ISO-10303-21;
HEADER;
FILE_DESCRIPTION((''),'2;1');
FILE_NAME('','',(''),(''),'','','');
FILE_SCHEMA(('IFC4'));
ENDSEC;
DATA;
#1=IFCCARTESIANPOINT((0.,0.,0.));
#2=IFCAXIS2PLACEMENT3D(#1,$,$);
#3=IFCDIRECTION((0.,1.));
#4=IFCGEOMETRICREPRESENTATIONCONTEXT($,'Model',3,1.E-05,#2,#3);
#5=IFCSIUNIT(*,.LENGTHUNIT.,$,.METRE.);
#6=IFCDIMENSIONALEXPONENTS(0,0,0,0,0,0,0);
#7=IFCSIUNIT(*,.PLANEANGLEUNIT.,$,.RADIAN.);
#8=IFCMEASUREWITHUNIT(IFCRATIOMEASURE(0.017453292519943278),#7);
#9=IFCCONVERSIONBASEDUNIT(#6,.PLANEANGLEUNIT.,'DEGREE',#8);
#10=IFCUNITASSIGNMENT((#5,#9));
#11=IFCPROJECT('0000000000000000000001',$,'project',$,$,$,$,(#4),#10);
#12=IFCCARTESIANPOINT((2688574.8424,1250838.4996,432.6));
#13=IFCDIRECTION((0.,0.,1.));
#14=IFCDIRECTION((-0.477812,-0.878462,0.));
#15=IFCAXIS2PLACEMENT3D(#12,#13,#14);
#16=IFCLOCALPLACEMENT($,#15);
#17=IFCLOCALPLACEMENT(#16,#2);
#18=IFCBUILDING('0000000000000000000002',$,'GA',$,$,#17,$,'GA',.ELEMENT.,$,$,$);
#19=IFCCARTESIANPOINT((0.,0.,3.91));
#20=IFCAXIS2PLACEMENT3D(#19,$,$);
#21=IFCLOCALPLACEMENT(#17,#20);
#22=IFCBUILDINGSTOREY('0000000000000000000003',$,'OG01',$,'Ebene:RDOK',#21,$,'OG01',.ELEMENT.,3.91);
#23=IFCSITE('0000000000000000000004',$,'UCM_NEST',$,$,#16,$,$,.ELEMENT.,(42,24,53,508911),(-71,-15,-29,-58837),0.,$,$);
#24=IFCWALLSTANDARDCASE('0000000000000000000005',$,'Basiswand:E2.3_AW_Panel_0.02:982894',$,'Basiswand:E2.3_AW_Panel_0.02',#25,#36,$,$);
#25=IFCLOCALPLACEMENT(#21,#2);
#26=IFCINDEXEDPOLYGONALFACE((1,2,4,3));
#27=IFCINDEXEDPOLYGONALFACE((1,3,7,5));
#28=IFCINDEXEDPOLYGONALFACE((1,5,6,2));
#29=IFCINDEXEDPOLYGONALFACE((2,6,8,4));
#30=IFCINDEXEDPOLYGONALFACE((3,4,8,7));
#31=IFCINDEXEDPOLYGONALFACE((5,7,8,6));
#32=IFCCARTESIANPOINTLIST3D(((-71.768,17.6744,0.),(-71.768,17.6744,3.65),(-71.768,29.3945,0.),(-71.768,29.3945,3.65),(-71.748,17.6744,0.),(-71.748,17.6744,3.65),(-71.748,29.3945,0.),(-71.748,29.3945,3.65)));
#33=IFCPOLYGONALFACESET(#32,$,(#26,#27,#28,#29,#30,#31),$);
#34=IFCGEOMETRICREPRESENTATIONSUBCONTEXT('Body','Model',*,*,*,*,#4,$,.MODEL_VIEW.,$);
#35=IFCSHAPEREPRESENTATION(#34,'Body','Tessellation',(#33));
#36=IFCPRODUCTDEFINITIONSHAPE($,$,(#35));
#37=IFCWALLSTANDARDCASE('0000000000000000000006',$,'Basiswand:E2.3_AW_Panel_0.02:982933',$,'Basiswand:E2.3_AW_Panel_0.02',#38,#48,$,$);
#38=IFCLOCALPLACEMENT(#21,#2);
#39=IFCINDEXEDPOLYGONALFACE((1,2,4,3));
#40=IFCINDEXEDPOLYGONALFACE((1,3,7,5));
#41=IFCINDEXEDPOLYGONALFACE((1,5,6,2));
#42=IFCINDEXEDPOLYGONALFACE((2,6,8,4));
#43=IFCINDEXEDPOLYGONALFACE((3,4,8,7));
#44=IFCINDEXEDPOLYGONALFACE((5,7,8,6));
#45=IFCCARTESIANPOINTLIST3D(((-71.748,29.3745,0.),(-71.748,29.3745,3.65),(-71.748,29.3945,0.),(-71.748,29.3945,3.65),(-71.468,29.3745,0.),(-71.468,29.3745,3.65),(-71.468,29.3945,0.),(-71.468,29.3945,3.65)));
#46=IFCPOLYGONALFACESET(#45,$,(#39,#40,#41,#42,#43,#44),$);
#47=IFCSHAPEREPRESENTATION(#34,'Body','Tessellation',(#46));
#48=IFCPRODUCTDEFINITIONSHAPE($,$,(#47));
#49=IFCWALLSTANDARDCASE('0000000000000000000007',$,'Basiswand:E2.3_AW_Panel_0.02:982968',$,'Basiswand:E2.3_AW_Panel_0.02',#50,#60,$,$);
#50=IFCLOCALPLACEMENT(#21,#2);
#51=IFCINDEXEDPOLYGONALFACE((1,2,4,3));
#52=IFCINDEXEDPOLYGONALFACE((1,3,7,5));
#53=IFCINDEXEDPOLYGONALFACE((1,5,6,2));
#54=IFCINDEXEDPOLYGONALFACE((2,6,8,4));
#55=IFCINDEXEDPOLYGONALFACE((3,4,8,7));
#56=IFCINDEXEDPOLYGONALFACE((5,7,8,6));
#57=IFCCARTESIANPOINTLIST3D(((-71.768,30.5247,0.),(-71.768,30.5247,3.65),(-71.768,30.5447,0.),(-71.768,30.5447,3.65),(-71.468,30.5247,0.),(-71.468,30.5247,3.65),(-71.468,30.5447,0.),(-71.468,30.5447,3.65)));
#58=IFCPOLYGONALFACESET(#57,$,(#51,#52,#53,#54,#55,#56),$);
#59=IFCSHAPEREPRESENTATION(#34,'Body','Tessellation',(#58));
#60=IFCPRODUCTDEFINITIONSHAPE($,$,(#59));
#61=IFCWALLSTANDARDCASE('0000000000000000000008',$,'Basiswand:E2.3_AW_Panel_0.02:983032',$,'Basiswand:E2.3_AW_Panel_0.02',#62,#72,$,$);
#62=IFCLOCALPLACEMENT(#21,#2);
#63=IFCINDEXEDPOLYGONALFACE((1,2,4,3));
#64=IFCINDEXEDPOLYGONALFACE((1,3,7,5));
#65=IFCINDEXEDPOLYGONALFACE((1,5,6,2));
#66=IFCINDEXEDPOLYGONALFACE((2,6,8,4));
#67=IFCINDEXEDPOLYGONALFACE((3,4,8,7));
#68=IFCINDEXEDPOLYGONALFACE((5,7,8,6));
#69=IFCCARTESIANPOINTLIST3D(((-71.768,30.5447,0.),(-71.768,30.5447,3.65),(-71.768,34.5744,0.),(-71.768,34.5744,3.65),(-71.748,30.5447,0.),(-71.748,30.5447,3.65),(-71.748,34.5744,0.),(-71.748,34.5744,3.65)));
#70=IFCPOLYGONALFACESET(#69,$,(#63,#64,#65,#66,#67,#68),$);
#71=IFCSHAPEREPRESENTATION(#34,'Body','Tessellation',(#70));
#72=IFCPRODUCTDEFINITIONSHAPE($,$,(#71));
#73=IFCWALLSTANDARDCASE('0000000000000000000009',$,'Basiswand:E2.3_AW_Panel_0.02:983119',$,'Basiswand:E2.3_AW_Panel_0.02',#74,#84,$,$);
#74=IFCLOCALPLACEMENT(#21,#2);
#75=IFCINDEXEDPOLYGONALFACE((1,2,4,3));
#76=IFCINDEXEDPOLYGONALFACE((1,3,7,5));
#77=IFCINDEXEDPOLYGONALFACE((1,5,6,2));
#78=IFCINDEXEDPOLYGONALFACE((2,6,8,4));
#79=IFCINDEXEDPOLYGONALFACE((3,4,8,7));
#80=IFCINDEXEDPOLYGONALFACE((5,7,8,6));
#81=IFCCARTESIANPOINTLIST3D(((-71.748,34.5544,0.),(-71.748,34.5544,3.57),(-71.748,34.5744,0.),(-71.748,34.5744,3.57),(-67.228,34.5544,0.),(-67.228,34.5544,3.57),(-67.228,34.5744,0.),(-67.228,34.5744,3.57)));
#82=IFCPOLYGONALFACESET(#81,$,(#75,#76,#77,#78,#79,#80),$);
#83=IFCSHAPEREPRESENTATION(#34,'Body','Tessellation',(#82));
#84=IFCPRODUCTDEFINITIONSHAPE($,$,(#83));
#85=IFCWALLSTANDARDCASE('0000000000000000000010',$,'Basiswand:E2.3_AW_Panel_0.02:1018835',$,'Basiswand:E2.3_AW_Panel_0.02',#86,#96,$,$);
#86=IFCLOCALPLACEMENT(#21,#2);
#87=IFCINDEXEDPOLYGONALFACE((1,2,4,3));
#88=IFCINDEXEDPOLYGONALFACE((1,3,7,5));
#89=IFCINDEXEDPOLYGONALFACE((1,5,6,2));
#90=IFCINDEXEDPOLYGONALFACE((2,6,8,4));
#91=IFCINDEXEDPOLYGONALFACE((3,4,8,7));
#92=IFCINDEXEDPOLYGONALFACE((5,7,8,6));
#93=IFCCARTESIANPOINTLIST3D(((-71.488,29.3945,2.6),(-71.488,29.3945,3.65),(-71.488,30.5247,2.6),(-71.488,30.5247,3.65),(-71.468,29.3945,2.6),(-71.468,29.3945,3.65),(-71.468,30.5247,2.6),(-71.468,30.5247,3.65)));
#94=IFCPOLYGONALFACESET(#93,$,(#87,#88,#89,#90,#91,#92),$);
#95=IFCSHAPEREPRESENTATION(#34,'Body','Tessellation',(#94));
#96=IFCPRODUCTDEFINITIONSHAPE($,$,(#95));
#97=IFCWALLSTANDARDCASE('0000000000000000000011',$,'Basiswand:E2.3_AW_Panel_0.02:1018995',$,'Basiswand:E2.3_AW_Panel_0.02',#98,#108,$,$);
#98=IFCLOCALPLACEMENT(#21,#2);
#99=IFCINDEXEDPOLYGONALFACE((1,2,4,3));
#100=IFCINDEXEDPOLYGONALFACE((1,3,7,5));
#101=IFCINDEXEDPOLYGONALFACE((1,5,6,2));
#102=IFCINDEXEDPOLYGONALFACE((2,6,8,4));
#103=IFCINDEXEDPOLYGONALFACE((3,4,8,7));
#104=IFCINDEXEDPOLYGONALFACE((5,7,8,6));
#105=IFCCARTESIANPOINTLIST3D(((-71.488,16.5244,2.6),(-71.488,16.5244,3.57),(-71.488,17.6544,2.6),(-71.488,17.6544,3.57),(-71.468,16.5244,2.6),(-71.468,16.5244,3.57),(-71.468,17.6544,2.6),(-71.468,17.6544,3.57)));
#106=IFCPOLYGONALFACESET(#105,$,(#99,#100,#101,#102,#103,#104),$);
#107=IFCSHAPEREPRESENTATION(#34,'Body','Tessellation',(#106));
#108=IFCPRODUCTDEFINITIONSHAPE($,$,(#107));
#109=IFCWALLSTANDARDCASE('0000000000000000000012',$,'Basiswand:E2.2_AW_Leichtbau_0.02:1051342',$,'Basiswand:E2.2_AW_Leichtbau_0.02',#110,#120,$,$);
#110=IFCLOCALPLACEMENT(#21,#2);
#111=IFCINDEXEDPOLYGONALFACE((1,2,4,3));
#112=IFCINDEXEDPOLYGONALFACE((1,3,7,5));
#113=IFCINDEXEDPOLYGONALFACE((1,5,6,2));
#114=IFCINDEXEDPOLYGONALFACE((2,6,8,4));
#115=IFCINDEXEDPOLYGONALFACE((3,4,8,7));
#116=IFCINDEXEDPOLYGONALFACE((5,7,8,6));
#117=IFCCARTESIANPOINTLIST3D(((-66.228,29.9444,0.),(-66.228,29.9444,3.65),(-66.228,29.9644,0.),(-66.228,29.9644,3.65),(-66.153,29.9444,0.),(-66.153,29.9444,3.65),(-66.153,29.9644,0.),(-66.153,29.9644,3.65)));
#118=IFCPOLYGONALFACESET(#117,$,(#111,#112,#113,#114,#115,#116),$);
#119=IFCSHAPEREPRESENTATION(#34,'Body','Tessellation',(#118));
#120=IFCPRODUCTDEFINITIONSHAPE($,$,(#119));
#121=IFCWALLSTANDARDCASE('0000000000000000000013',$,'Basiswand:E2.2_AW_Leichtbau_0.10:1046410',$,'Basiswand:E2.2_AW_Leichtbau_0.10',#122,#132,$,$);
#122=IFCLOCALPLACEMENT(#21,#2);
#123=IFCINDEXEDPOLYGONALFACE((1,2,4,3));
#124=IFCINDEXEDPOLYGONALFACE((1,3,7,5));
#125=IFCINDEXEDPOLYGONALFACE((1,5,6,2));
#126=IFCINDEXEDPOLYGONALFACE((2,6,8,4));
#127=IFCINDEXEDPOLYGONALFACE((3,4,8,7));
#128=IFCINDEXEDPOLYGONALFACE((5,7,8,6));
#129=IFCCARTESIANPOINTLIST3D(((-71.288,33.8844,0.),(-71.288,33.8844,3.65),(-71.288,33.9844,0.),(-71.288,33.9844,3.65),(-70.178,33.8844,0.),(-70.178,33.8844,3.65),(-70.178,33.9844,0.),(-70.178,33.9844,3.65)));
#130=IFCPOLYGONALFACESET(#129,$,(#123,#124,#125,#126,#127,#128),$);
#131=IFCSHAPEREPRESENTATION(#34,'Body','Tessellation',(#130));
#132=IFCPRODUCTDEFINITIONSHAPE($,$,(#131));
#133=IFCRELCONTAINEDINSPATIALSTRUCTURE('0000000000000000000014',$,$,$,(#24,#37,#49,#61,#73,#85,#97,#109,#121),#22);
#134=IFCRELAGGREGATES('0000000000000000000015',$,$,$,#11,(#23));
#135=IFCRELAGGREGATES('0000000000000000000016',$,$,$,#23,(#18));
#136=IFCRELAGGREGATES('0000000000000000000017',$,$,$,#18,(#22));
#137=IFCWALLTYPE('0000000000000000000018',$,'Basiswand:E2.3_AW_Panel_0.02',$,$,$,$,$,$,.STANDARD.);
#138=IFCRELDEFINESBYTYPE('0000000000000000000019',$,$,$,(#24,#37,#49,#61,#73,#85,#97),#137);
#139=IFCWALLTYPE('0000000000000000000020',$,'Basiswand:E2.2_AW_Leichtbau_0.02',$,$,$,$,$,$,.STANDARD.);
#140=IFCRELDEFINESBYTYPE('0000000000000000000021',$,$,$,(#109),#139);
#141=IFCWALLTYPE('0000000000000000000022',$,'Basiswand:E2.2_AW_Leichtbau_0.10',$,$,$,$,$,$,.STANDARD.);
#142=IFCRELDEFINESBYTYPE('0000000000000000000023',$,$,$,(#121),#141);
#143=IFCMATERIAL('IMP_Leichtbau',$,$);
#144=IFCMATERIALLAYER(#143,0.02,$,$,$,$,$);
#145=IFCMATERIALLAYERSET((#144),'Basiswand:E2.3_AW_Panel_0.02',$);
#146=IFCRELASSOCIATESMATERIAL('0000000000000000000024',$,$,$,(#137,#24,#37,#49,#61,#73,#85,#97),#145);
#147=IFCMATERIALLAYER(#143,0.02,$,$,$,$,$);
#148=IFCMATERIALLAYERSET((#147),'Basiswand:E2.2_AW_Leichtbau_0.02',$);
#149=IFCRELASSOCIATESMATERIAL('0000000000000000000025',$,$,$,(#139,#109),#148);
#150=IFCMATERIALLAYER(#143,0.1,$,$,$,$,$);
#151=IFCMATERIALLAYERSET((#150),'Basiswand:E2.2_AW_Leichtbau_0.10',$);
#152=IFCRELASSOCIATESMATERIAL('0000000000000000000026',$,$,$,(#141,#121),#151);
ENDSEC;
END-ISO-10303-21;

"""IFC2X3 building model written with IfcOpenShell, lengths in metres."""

from ifc_helpers import new_model, entity, si_unit, converted_unit, direction, frame, frame_2d, origin, place, context, subcontext, project, spatial, polyline, rectangle, extrude, clip, bounded_halfspace, material, layer, layer_set, layer_usage, type_object, element, save


model = new_model("IFC2X3")

# Units and contexts
model_context = context("Model", 3, precision=1e-05, world=origin(), true_north=direction((0.0, 1.0)))
body_context = subcontext(model_context, "Body", "Model", "MODEL_VIEW")
ifc_project = project(units=[si_unit("LENGTHUNIT", "METRE"), converted_unit("PLANEANGLEUNIT", "DEGREE", entity("IfcRatioMeasure", 0.017453292519943278), si_unit("PLANEANGLEUNIT", "RADIAN"), dimensions=[0, 0, 0, 0, 0, 0, 0])], contexts=[model_context])

# Site, building, storey
site_placement = place(None, frame((2688574.8424, 1250838.4996, 432.6), z_axis=(0.0, 0.0, 1.0), x_axis=(-0.477812, -0.878462, 0.0)))
site = spatial("IfcSite", under=ifc_project, at=site_placement, Name="UCM_NEST", CompositionType="ELEMENT", RefLatitude=(42, 24, 53, 508911), RefLongitude=(-71, -15, -29, -58837), RefElevation=0.0)
building_placement = place(site_placement, origin())
building = spatial("IfcBuilding", under=site, at=building_placement, Name="GA", LongName="GA", CompositionType="ELEMENT")
storey_placement = place(building_placement, frame((0.0, 0.0, 3.91)))
storey = spatial("IfcBuildingStorey", under=building, at=storey_placement, Name="OG01", ObjectType="Ebene:RDOK", LongName="OG01", CompositionType="ELEMENT", Elevation=3.91)

# Shared definitions
ifc_material_1 = material(Name="IMP_Leichtbau")

# Walls
ifc_layer_1 = layer(ifc_material_1, 0.02)
ifc_layer_set_1 = layer_set([ifc_layer_1], Name="Basiswand:E2.3_AW_Panel_0.02")
ifc_layer_usage_1 = layer_usage(ifc_layer_set_1, "AXIS2", "NEGATIVE", 0.01)
wall_type_1 = type_object("IfcWallType", Name="Basiswand:E2.3_AW_Panel_0.02", PredefinedType="STANDARD", material=ifc_layer_set_1)
wall_1_placement = place(storey_placement, frame((-71.758, 17.6744, 0.0), z_axis=(0.0, 0.0, 1.0), x_axis=(0.0, 1.0, 0.0)))
element("IfcWallStandardCase", 1, at=wall_1_placement, inside=storey, type_object=wall_type_1, material=ifc_layer_usage_1, Name="Basiswand:E2.3_AW_Panel_0.02:982894", ObjectType="Basiswand:E2.3_AW_Panel_0.02", context=body_context, shape_type="SweptSolid", body=[
    extrude(rectangle(XDim=11.72, YDim=0.02, at=frame_2d((5.86, 0.0), x_axis=(-1.0, 0.0))), origin(), (0.0, 0.0, 1.0), 3.65),
])
wall_2_placement = place(storey_placement, frame((-71.748, 29.3845, 0.0)))
element("IfcWallStandardCase", 2, at=wall_2_placement, inside=storey, type_object=wall_type_1, material=ifc_layer_usage_1, Name="Basiswand:E2.3_AW_Panel_0.02:982933", ObjectType="Basiswand:E2.3_AW_Panel_0.02", context=body_context, shape_type="SweptSolid", body=[
    extrude(rectangle(XDim=0.28, YDim=0.02, at=frame_2d((0.14, 0.0), x_axis=(-1.0, 0.0))), origin(), (0.0, 0.0, 1.0), 3.65),
])
wall_3_placement = place(storey_placement, frame((-71.468, 30.5347, 0.0), z_axis=(0.0, 0.0, 1.0), x_axis=(-1.0, 0.0, 0.0)))
element("IfcWallStandardCase", 3, at=wall_3_placement, inside=storey, type_object=wall_type_1, material=ifc_layer_usage_1, Name="Basiswand:E2.3_AW_Panel_0.02:982968", ObjectType="Basiswand:E2.3_AW_Panel_0.02", context=body_context, shape_type="SweptSolid", body=[
    extrude(rectangle(XDim=0.3, YDim=0.02, at=frame_2d((0.15, 0.0), x_axis=(-1.0, 0.0))), origin(), (0.0, 0.0, 1.0), 3.65),
])
wall_4_placement = place(storey_placement, frame((-71.758, 30.5447, 0.0), z_axis=(0.0, 0.0, 1.0), x_axis=(0.0, 1.0, 0.0)))
element("IfcWallStandardCase", 4, at=wall_4_placement, inside=storey, type_object=wall_type_1, material=ifc_layer_usage_1, Name="Basiswand:E2.3_AW_Panel_0.02:983032", ObjectType="Basiswand:E2.3_AW_Panel_0.02", context=body_context, shape_type="SweptSolid", body=[
    extrude(rectangle(XDim=4.0298, YDim=0.02, at=frame_2d((2.0149, 0.0), x_axis=(-1.0, 0.0))), origin(), (0.0, 0.0, 1.0), 3.65),
])
wall_5_placement = place(storey_placement, frame((-71.748, 34.5644, 0.0)))
element("IfcWallStandardCase", 5, at=wall_5_placement, inside=storey, type_object=wall_type_1, material=ifc_layer_usage_1, Name="Basiswand:E2.3_AW_Panel_0.02:983119", ObjectType="Basiswand:E2.3_AW_Panel_0.02", context=body_context, shape_type="Clipping", body=[
    clip(extrude(rectangle(XDim=4.52, YDim=0.02, at=frame_2d((2.26, 0.0), x_axis=(-1.0, 0.0))), origin(), (0.0, 0.0, 1.0), 3.57), bounded_halfspace(frame((0.0, -0.01, 3.57), z_axis=(0.0, 0.0, -1.0), x_axis=(0.0, -1.0, 0.0)), True, frame((0.0, -0.01, 3.57), z_axis=(0.0, 0.0, -1.0), x_axis=(0.0, -1.0, 0.0)), polyline([(0.0, 0.0), (-0.02, 0.0), (-0.02, -4.52), (0.0, -4.52), (0.0, 0.0)]))),
])
wall_6_placement = place(storey_placement, frame((-71.478, 30.5247, 2.6), z_axis=(0.0, 0.0, 1.0), x_axis=(0.0, -1.0, 0.0)))
element("IfcWallStandardCase", 6, at=wall_6_placement, inside=storey, type_object=wall_type_1, material=ifc_layer_usage_1, Name="Basiswand:E2.3_AW_Panel_0.02:1018835", ObjectType="Basiswand:E2.3_AW_Panel_0.02", context=body_context, shape_type="SweptSolid", body=[
    extrude(rectangle(XDim=1.1302, YDim=0.02, at=frame_2d((0.5651, 0.0), x_axis=(-1.0, 0.0))), origin(), (0.0, 0.0, 1.0), 1.05),
])
wall_7_placement = place(storey_placement, frame((-71.478, 17.6544, 2.6), z_axis=(0.0, 0.0, 1.0), x_axis=(0.0, -1.0, 0.0)))
element("IfcWallStandardCase", 7, at=wall_7_placement, inside=storey, type_object=wall_type_1, material=ifc_layer_usage_1, Name="Basiswand:E2.3_AW_Panel_0.02:1018995", ObjectType="Basiswand:E2.3_AW_Panel_0.02", context=body_context, shape_type="Clipping", body=[
    clip(extrude(rectangle(XDim=1.13, YDim=0.02, at=frame_2d((0.565, 0.0), x_axis=(-1.0, 0.0))), origin(), (0.0, 0.0, 1.0), 0.97), bounded_halfspace(frame((0.0, -0.01, 0.97), z_axis=(0.0, 0.0, -1.0), x_axis=(1.0, 0.0, 0.0)), True, frame((0.0, -0.01, 0.97), z_axis=(0.0, 0.0, -1.0), x_axis=(1.0, 0.0, 0.0)), polyline([(0.0, 0.0), (0.0, -0.02), (1.13, -0.02), (1.13, 0.0), (0.0, 0.0)]))),
])
ifc_layer_2 = layer(ifc_material_1, 0.02)
ifc_layer_set_2 = layer_set([ifc_layer_2], Name="Basiswand:E2.2_AW_Leichtbau_0.02")
ifc_layer_usage_2 = layer_usage(ifc_layer_set_2, "AXIS2", "NEGATIVE", 0.01)
wall_type_2 = type_object("IfcWallType", Name="Basiswand:E2.2_AW_Leichtbau_0.02", PredefinedType="STANDARD", material=ifc_layer_set_2)
wall_8_placement = place(storey_placement, frame((-66.228, 29.9544, 0.0)))
element("IfcWallStandardCase", 8, at=wall_8_placement, inside=storey, type_object=wall_type_2, material=ifc_layer_usage_2, Name="Basiswand:E2.2_AW_Leichtbau_0.02:1051342", ObjectType="Basiswand:E2.2_AW_Leichtbau_0.02", context=body_context, shape_type="SweptSolid", body=[
    extrude(rectangle(XDim=0.075, YDim=0.02, at=frame_2d((0.0375, 0.0), x_axis=(-1.0, 0.0))), origin(), (0.0, 0.0, 1.0), 3.65),
])
ifc_layer_3 = layer(ifc_material_1, 0.1)
ifc_layer_set_3 = layer_set([ifc_layer_3], Name="Basiswand:E2.2_AW_Leichtbau_0.10")
ifc_layer_usage_3 = layer_usage(ifc_layer_set_3, "AXIS2", "NEGATIVE", 0.05)
wall_type_3 = type_object("IfcWallType", Name="Basiswand:E2.2_AW_Leichtbau_0.10", PredefinedType="STANDARD", material=ifc_layer_set_3)
wall_9_placement = place(storey_placement, frame((-70.178, 33.9344, 0.0), z_axis=(0.0, 0.0, 1.0), x_axis=(-1.0, 0.0, 0.0)))
element("IfcWallStandardCase", 9, at=wall_9_placement, inside=storey, type_object=wall_type_3, material=ifc_layer_usage_3, Name="Basiswand:E2.2_AW_Leichtbau_0.10:1046410", ObjectType="Basiswand:E2.2_AW_Leichtbau_0.10", context=body_context, shape_type="SweptSolid", body=[
    extrude(rectangle(XDim=1.11, YDim=0.1, at=frame_2d((0.555, 0.0), x_axis=(-1.0, 0.0))), origin(), (0.0, 0.0, 1.0), 3.65),
])

save(model, "model.ifc")
